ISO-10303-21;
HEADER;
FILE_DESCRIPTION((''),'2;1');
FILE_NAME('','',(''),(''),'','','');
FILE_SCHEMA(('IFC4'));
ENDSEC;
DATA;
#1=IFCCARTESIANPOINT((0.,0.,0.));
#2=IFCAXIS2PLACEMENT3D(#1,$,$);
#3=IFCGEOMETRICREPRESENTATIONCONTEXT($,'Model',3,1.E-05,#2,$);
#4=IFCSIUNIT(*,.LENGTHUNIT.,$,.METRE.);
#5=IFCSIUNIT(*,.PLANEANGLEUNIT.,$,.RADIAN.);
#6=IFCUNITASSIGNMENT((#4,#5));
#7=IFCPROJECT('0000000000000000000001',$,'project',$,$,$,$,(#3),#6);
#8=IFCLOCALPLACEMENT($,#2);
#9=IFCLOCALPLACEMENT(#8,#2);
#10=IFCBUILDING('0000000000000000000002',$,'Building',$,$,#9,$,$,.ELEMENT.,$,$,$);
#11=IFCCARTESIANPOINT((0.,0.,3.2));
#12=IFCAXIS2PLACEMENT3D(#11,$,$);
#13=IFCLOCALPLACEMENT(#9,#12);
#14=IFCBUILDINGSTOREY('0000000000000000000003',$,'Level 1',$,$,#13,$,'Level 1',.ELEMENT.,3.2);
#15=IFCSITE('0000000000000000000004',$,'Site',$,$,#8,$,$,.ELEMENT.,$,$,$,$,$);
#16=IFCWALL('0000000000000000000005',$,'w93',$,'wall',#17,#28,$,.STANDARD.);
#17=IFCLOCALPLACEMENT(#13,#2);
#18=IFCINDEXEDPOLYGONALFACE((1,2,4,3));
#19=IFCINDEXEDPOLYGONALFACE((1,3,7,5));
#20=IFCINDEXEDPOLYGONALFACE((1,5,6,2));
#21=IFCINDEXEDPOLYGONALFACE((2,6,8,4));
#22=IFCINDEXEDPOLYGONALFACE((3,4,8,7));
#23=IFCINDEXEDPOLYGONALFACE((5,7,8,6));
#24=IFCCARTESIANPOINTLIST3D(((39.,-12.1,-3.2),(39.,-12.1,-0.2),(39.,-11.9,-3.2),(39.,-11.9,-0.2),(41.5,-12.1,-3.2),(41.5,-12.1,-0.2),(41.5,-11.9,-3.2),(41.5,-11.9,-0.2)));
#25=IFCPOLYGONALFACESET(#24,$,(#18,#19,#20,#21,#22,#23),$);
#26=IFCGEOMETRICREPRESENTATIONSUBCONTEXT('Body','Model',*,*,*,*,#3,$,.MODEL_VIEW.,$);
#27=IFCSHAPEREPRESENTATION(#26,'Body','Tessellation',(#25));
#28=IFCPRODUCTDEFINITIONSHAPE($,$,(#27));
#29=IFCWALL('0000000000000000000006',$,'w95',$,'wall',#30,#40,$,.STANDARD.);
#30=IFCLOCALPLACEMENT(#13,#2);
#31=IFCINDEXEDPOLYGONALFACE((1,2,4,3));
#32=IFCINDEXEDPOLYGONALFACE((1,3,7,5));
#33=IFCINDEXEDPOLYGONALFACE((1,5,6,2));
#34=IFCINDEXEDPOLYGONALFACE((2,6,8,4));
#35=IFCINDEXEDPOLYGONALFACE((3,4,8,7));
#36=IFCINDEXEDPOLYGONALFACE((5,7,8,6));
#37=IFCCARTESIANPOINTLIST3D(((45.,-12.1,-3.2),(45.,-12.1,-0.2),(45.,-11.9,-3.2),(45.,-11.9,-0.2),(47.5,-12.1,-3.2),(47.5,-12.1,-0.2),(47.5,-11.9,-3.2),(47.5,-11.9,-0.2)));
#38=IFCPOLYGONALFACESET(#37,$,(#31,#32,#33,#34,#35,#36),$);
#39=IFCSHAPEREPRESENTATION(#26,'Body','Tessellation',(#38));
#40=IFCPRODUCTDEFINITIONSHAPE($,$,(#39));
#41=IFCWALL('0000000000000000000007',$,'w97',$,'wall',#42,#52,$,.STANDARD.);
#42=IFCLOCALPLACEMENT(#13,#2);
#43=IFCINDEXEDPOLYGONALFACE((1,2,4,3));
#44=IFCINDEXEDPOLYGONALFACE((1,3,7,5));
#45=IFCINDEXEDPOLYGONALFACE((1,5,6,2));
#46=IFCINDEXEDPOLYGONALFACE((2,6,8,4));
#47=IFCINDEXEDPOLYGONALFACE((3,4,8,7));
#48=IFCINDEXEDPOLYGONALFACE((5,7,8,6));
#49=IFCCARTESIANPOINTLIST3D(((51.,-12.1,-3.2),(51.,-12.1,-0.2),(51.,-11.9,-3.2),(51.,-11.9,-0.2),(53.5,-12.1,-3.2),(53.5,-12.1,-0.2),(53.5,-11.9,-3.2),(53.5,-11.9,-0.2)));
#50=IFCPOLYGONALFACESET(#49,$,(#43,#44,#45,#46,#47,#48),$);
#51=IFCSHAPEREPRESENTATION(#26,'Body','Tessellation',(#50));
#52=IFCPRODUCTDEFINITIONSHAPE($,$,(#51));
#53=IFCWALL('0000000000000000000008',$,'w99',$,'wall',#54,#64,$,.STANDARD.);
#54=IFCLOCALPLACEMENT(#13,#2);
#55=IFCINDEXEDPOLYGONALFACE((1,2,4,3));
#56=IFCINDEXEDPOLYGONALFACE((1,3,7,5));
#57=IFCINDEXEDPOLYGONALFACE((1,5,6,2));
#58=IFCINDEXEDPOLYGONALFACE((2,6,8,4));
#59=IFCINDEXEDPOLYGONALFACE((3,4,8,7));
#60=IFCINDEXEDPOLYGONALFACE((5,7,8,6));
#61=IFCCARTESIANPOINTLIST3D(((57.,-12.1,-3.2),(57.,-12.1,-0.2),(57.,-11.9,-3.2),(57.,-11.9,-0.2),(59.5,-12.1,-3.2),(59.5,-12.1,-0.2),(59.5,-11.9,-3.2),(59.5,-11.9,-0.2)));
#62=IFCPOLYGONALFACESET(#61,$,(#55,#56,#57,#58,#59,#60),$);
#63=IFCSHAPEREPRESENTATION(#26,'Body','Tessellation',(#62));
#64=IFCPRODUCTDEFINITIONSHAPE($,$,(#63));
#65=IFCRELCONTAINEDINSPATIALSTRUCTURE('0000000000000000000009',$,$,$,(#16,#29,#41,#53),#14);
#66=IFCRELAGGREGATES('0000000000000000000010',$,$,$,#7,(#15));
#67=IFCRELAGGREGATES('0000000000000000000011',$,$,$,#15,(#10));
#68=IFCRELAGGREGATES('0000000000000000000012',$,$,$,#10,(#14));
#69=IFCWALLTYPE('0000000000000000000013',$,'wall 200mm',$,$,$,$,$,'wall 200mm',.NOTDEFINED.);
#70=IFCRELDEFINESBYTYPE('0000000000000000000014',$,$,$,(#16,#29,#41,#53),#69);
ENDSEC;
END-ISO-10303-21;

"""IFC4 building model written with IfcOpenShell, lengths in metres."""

from ifc_helpers import new_model, si_unit, frame, frame_2d, origin, place, context, subcontext, project, spatial, rectangle, extrude, type_object, element, save


model = new_model("IFC4")

# Units and contexts
model_context = context("Model", 3, precision=1e-05, world=origin())
body_context = subcontext(model_context, "Body", "Model", "MODEL_VIEW")
ifc_project = project(units=[si_unit("LENGTHUNIT", "METRE"), si_unit("PLANEANGLEUNIT", "RADIAN")], contexts=[model_context])

# Site, building, storey
site_placement = place(None, origin())
site = spatial("IfcSite", under=ifc_project, at=site_placement, Name="Site", CompositionType="ELEMENT")
building_placement = place(site_placement, origin())
building = spatial("IfcBuilding", under=site, at=building_placement, Name="Building", CompositionType="ELEMENT")
storey_placement = place(building_placement, frame((0.0, 0.0, 3.2)))
storey = spatial("IfcBuildingStorey", under=building, at=storey_placement, Name="Level 1", LongName="Level 1", CompositionType="ELEMENT", Elevation=3.2)

# Walls
wall_type = type_object("IfcWallType", Name="wall 200mm", ElementType="wall 200mm", PredefinedType="NOTDEFINED")
for number, where, z_axis, x_axis, name in (
    (1, (39.0, -12.0, -3.2), (0.0, 0.0, 1.0), (1.0, 0.0, 0.0), "w93"),
    (2, (45.0, -12.0, -3.2), (0.0, 0.0, 1.0), (1.0, 0.0, 0.0), "w95"),
    (3, (51.0, -12.0, -3.2), (0.0, 0.0, 1.0), (1.0, 0.0, 0.0), "w97"),
    (4, (57.0, -12.0, -3.2), (0.0, 0.0, 1.0), (1.0, 0.0, 0.0), "w99"),
):
    element("IfcWall", number, at=place(storey_placement, frame(where, z_axis=z_axis, x_axis=x_axis)), inside=storey, type_object=wall_type, Name=name, ObjectType="wall", PredefinedType="STANDARD", context=body_context, shape_type="SweptSolid", body=[
        extrude(rectangle(XDim=2.5, YDim=0.2, at=frame_2d((1.25, 0.0))), origin(), (0.0, 0.0, 1.0), 3.0),
    ])

save(model, "model.ifc")
